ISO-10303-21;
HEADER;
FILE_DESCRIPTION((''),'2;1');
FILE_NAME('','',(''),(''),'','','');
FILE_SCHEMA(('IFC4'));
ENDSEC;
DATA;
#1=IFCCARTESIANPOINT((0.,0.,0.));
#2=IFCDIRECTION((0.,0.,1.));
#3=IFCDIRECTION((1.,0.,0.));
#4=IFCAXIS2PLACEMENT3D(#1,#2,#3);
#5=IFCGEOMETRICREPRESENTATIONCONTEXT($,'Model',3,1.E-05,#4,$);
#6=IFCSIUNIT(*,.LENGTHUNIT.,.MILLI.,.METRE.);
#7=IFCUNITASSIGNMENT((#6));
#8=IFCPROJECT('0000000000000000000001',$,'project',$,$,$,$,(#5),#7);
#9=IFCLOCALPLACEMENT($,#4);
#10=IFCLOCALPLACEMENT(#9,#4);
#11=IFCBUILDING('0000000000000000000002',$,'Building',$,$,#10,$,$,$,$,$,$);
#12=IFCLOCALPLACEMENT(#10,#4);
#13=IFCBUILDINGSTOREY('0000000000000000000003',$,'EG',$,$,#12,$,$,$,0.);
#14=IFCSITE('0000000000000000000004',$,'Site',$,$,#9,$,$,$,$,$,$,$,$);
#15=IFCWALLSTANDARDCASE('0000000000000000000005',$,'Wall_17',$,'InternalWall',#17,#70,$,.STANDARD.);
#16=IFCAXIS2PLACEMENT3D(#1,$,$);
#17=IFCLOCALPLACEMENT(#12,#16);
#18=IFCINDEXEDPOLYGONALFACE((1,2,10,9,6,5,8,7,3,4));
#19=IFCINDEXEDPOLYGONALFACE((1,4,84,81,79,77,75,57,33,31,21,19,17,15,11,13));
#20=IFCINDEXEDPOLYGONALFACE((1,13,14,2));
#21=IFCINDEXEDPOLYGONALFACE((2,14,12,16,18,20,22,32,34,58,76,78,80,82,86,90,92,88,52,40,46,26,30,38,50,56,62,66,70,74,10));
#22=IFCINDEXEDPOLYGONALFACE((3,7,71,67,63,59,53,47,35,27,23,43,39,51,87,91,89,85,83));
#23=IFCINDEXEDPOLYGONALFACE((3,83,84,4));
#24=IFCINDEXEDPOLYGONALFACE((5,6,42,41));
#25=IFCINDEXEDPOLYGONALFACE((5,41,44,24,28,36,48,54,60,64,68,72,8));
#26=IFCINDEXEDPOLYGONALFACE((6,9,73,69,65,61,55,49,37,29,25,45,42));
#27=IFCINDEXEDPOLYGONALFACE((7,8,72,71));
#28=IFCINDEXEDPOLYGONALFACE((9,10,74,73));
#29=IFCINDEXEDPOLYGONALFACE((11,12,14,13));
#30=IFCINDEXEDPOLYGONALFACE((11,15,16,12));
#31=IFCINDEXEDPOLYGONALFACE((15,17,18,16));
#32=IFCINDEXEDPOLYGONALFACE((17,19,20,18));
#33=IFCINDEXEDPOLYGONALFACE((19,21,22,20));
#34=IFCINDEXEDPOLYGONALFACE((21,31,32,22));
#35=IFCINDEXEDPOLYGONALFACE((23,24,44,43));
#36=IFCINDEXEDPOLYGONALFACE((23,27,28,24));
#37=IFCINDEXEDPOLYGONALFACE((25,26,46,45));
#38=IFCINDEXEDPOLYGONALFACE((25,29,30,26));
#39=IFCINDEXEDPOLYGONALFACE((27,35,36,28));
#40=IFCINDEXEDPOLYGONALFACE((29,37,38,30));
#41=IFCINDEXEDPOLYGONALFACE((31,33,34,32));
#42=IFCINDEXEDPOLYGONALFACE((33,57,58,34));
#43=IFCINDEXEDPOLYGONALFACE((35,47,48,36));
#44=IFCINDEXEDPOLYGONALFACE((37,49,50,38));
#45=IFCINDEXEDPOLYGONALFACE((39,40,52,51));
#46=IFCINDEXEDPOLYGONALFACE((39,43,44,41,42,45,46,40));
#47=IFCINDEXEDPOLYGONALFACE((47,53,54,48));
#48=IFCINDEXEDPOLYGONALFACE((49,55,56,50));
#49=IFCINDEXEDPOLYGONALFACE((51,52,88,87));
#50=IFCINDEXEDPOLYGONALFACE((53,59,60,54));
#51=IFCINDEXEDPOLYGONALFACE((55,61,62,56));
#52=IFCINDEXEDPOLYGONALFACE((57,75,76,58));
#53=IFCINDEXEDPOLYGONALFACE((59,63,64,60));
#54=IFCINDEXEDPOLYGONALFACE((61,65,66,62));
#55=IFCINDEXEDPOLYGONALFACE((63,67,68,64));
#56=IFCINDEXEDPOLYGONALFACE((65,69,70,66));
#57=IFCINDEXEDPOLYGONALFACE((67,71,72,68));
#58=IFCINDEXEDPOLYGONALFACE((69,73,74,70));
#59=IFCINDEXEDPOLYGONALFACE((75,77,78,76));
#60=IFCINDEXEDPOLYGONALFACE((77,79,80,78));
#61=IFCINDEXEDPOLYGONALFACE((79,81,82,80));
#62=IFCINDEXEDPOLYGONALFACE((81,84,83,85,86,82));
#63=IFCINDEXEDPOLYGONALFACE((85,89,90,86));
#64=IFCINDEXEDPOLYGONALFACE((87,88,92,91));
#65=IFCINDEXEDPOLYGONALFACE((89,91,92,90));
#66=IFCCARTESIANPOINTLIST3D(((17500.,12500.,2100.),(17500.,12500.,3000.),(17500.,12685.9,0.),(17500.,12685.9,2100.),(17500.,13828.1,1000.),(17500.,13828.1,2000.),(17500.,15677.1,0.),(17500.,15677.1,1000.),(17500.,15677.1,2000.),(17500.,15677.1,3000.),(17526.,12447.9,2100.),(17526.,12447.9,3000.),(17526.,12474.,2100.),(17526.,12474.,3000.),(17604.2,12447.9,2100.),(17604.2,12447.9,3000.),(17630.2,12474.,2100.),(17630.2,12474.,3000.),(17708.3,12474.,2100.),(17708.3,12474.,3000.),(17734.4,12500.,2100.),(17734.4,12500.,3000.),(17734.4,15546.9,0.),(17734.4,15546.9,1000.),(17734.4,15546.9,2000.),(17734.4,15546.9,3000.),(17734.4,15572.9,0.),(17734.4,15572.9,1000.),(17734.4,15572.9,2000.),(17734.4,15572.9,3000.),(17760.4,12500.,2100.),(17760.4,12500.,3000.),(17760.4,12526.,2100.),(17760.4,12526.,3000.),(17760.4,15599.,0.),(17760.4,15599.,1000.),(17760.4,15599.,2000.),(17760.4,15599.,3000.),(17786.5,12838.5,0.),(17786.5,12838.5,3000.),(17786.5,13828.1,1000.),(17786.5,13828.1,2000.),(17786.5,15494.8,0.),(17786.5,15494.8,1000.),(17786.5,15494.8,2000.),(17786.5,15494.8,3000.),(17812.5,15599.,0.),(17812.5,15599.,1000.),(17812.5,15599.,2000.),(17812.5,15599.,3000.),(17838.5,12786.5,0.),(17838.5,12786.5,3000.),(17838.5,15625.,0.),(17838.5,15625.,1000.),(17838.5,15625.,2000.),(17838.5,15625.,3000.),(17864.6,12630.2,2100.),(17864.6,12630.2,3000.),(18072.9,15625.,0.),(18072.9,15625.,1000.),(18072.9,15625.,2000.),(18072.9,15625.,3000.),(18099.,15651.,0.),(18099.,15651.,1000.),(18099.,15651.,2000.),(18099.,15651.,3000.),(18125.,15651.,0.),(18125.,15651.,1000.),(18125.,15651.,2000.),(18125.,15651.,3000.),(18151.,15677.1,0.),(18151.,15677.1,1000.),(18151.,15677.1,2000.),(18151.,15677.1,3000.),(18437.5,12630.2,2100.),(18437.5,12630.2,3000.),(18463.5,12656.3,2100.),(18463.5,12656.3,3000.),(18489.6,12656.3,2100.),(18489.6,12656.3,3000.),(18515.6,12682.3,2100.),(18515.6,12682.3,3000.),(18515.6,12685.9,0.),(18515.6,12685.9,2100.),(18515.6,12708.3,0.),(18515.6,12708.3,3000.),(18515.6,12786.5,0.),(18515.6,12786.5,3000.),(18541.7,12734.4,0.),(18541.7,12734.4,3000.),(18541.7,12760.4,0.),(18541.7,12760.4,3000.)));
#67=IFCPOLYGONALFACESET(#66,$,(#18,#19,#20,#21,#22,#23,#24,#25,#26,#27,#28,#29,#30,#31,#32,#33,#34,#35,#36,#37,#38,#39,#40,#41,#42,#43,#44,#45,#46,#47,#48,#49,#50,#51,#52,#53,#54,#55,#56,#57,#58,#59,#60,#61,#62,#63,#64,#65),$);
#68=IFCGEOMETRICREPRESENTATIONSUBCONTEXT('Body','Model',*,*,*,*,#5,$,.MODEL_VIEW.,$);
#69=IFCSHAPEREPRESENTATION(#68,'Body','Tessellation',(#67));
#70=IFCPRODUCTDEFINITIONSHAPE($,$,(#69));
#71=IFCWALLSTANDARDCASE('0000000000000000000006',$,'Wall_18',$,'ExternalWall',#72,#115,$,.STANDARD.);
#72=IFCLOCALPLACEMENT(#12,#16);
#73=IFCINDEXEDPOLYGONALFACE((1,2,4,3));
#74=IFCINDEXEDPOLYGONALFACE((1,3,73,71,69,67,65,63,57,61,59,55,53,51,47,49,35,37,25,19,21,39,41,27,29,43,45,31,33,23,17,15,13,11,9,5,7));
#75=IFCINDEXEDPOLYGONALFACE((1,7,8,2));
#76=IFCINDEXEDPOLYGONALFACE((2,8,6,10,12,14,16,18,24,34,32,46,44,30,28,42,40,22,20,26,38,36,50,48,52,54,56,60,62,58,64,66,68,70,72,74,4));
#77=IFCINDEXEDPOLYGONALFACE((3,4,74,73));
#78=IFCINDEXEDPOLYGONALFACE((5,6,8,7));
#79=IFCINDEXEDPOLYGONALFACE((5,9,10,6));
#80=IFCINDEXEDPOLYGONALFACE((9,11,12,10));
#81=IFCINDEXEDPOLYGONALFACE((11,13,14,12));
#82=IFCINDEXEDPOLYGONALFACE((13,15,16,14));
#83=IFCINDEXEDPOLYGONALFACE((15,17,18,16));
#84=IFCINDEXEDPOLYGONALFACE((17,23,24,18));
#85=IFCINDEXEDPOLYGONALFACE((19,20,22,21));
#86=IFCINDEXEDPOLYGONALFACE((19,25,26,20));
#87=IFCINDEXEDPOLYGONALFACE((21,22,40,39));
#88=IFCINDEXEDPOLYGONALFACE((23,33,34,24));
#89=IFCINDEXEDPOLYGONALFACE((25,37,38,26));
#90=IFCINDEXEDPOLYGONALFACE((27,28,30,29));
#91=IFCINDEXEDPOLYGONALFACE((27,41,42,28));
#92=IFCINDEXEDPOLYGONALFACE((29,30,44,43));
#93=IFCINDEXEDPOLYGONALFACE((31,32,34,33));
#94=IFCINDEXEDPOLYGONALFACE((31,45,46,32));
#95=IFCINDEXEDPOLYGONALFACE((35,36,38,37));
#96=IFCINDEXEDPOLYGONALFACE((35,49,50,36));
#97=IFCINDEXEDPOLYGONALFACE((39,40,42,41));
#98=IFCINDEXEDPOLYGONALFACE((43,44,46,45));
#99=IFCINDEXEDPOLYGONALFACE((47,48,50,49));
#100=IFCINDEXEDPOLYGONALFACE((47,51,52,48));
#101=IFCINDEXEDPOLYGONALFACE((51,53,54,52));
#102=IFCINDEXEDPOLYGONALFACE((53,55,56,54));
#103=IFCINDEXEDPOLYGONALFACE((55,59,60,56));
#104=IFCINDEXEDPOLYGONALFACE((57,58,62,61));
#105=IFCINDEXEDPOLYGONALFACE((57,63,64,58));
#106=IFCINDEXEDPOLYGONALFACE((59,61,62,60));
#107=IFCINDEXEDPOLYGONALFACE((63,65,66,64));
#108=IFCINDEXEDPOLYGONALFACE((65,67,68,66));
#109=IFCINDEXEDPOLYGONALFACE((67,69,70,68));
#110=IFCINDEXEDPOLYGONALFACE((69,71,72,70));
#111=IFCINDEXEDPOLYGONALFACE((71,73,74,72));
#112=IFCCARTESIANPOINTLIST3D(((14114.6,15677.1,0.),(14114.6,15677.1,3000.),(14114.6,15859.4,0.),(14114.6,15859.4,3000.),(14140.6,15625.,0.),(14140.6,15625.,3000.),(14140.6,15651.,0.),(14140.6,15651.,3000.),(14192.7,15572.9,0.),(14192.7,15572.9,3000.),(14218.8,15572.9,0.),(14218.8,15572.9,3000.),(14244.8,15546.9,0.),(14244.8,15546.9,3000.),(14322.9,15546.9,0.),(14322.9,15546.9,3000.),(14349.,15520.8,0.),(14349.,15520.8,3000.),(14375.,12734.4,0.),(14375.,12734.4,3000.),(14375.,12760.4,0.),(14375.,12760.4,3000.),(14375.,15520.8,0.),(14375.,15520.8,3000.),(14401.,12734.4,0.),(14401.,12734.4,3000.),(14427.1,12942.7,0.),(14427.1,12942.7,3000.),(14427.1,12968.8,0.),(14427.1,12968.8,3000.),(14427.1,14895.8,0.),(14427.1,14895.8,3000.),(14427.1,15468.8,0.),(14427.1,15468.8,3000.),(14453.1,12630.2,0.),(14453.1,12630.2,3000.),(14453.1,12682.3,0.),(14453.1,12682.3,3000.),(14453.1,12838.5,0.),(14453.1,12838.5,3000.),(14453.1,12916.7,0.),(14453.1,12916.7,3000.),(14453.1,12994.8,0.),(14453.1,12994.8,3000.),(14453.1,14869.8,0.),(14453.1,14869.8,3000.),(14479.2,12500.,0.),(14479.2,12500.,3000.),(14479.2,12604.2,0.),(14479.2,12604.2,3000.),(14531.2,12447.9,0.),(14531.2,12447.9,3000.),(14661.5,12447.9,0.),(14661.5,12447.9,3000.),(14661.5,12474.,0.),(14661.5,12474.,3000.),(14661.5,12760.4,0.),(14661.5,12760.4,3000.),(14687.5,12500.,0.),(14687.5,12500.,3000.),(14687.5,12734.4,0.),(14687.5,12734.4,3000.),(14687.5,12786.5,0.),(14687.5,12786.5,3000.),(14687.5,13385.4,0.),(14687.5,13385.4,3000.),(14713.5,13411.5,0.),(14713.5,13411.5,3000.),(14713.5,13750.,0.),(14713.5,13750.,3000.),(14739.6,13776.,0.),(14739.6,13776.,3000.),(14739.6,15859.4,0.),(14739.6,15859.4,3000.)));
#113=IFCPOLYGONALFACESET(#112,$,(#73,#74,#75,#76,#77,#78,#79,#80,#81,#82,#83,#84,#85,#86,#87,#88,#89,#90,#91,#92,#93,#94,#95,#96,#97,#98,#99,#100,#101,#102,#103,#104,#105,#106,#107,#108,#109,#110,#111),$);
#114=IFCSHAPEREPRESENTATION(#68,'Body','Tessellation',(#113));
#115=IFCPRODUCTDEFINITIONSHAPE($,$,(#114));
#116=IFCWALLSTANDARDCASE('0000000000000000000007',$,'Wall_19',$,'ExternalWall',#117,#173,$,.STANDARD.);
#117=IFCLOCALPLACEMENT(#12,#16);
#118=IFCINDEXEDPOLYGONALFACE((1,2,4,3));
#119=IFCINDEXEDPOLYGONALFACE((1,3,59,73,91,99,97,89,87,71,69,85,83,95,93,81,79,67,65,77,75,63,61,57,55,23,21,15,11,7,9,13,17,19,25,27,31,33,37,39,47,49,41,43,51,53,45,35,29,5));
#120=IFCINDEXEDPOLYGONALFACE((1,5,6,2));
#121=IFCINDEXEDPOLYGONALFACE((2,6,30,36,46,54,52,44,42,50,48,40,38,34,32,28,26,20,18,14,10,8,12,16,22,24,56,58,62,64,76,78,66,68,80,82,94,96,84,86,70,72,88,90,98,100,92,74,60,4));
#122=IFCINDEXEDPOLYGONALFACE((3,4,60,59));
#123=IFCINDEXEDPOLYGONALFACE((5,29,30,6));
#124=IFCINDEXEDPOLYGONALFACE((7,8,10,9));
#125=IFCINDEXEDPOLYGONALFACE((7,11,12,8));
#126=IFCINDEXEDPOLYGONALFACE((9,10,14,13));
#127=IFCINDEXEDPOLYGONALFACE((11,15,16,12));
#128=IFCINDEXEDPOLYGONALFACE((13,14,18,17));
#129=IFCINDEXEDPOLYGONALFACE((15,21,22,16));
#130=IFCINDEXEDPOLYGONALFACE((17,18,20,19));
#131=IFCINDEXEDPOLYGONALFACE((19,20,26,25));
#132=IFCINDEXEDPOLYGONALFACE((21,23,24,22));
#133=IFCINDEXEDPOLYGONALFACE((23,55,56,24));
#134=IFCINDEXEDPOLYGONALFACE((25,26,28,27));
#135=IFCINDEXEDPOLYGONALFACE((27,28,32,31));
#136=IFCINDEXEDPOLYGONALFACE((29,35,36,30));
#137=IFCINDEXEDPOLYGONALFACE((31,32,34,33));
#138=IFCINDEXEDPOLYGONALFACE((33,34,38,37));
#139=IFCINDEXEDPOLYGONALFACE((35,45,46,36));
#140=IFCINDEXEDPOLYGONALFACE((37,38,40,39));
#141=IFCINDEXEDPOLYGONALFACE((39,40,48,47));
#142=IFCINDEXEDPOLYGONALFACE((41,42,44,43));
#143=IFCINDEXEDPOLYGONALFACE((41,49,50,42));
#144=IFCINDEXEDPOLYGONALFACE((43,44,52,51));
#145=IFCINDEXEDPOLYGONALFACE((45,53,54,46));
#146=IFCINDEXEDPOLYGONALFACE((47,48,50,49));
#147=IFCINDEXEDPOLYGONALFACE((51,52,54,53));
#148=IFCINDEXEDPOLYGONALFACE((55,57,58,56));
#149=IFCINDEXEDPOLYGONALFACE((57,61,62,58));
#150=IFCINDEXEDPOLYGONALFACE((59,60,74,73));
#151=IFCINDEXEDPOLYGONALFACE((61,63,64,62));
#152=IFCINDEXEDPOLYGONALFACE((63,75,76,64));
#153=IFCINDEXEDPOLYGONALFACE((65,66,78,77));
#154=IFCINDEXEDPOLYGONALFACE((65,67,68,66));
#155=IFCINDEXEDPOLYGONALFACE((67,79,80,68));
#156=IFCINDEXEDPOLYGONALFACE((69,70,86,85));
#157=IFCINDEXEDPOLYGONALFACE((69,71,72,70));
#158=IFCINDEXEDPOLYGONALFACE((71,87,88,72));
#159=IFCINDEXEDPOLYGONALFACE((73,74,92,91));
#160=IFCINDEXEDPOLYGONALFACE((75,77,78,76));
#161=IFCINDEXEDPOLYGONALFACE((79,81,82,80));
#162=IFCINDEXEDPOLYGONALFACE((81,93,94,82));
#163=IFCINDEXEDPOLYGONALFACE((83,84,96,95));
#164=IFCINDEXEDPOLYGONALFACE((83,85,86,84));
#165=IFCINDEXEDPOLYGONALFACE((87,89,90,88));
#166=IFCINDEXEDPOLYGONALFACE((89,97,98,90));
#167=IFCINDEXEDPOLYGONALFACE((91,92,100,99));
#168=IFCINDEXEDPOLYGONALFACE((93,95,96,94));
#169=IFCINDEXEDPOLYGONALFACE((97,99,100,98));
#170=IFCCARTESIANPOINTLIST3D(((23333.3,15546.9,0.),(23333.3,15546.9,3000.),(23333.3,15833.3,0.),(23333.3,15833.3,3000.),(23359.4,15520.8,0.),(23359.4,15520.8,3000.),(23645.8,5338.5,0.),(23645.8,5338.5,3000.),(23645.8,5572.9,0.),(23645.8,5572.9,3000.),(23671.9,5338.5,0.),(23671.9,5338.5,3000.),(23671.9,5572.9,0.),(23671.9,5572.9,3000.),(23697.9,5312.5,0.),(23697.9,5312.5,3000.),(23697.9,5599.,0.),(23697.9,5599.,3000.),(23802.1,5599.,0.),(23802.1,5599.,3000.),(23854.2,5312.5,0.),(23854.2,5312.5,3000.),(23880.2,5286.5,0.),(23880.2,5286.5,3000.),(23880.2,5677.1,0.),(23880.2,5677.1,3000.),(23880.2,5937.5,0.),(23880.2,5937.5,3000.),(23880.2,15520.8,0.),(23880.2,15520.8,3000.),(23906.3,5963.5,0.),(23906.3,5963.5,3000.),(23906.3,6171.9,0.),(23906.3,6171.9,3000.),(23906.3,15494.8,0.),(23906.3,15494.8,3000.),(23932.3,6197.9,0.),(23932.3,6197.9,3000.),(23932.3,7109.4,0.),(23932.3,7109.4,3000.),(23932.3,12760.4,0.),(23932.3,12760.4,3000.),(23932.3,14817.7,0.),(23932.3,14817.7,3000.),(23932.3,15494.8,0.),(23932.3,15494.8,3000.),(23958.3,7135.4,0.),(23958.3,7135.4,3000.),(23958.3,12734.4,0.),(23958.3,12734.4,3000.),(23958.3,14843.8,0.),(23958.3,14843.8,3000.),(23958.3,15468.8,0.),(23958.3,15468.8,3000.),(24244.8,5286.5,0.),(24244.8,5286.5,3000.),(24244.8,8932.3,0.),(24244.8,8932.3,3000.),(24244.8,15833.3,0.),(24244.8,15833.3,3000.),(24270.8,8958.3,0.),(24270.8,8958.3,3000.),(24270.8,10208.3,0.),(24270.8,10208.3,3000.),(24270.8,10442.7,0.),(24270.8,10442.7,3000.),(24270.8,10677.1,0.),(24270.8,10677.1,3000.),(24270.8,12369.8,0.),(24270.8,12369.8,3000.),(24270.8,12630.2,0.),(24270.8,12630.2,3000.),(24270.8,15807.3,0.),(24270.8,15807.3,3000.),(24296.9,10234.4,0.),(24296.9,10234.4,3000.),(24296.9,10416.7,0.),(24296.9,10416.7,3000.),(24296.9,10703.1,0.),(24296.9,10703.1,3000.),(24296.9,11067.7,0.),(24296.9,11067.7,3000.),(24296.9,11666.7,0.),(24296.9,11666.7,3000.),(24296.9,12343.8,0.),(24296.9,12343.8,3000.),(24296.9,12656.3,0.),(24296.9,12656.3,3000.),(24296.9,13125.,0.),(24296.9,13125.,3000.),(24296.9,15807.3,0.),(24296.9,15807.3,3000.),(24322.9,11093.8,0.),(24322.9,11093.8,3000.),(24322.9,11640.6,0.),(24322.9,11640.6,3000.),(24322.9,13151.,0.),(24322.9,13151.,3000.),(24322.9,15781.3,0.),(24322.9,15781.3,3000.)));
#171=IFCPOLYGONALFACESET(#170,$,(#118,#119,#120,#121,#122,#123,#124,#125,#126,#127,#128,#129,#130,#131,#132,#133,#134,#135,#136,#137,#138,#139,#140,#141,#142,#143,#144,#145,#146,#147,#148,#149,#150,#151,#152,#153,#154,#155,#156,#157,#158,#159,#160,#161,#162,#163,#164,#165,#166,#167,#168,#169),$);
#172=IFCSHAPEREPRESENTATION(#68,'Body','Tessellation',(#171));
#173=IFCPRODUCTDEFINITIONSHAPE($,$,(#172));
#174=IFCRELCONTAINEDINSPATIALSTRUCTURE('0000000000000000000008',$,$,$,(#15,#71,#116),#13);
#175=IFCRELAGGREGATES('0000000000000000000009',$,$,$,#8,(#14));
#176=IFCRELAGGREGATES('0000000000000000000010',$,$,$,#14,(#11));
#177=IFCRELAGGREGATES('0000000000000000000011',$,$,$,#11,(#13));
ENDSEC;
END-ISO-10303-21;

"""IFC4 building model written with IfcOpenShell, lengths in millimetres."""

from ifc_helpers import new_model, si_unit, frame, origin_with_axes, place, context, subcontext, project, spatial, polyline, rectangle, outline, extrude, element, save


model = new_model("IFC4")

# Units and contexts
model_context = context("Model", 3, precision=1e-05, world=origin_with_axes())
body_context = subcontext(model_context, "Body", "Model", "MODEL_VIEW")
ifc_project = project(units=[si_unit("LENGTHUNIT", "METRE", prefix="MILLI")], contexts=[model_context])

# Site, building, storey
site_placement = place(None, origin_with_axes())
site = spatial("IfcSite", under=ifc_project, at=site_placement, Name="Site")
building_placement = place(site_placement, origin_with_axes())
building = spatial("IfcBuilding", under=site, at=building_placement, Name="Building")
storey_placement = place(building_placement, origin_with_axes())
storey = spatial("IfcBuildingStorey", under=building, at=storey_placement, Name="EG", Elevation=0.0)

# Wall, openings
wall_1_placement = place(storey_placement, origin_with_axes())
wall_1 = element("IfcWallStandardCase", 1, at=wall_1_placement, inside=storey, Name="Wall_17", ObjectType="InternalWall", PredefinedType="STANDARD", context=body_context, shape_type="SweptSolid", body=[
    extrude(outline(polyline([(17526.0, 12447.9, 0.0), (17526.0, 12474.0, 0.0), (17500.0, 12500.0, 0.0), (17500.0, 15677.1, 0.0), (18151.0, 15677.1, 0.0), (18125.0, 15651.0, 0.0), (18099.0, 15651.0, 0.0), (18072.9, 15625.0, 0.0), (17838.5, 15625.0, 0.0), (17812.5, 15599.0, 0.0), (17760.4, 15599.0, 0.0), (17734.4, 15572.9, 0.0), (17734.4, 15546.9, 0.0), (17786.5, 15494.8, 0.0), (17786.5, 12838.5, 0.0), (17838.5, 12786.5, 0.0), (18515.6, 12786.5, 0.0), (18541.7, 12760.4, 0.0), (18541.7, 12734.4, 0.0), (18515.6, 12708.3, 0.0), (18515.6, 12682.3, 0.0), (18489.6, 12656.3, 0.0), (18463.5, 12656.3, 0.0), (18437.5, 12630.2, 0.0), (17864.6, 12630.2, 0.0), (17760.4, 12526.0, 0.0), (17760.4, 12500.0, 0.0), (17734.4, 12500.0, 0.0), (17708.3, 12474.0, 0.0), (17630.2, 12474.0, 0.0), (17604.2, 12447.9, 0.0), (17526.0, 12447.9, 0.0)])), origin_with_axes(), (0.0, 0.0, 1.0), 3000.0),
])
opening_1_placement = place(wall_1_placement, origin_with_axes())
element("IfcOpeningElement", 2, at=opening_1_placement, inside=storey, cuts=wall_1, context=body_context, shape_type="SweptSolid", body=[
    extrude(rectangle(XDim=450.0, YDim=1041.7), frame((18020.8, 12460.9, 0.0), z_axis=(0.0, 0.0, 1.0), x_axis=(0.0, 1.0, 0.0)), (0.0, 0.0, 1.0), 2100.0),
])
opening_2_placement = place(wall_1_placement, origin_with_axes())
element("IfcOpeningElement", 3, at=opening_2_placement, inside=storey, cuts=wall_1, context=body_context, shape_type="SweptSolid", body=[
    extrude(rectangle(XDim=1849.0, YDim=1041.7), frame((18020.8, 14752.6, 1000.0), z_axis=(0.0, 0.0, 1.0), x_axis=(0.0, 1.0, 0.0)), (0.0, 0.0, 1.0), 1000.0),
])

# Wall, opening
wall_2_placement = place(storey_placement, origin_with_axes())
wall_2 = element("IfcWallStandardCase", 4, at=wall_2_placement, inside=storey, Name="Wall_18", ObjectType="ExternalWall", PredefinedType="STANDARD", context=body_context, shape_type="SweptSolid", body=[
    extrude(outline(polyline([(14531.2, 12447.9, 0.0), (14479.2, 12500.0, 0.0), (14479.2, 12604.2, 0.0), (14453.1, 12630.2, 0.0), (14453.1, 12682.3, 0.0), (14401.0, 12734.4, 0.0), (14375.0, 12734.4, 0.0), (14375.0, 12760.4, 0.0), (14453.1, 12838.5, 0.0), (14453.1, 12916.7, 0.0), (14427.1, 12942.7, 0.0), (14427.1, 12968.8, 0.0), (14453.1, 12994.8, 0.0), (14453.1, 14869.8, 0.0), (14427.1, 14895.8, 0.0), (14427.1, 15468.8, 0.0), (14375.0, 15520.8, 0.0), (14349.0, 15520.8, 0.0), (14322.9, 15546.9, 0.0), (14244.8, 15546.9, 0.0), (14218.8, 15572.9, 0.0), (14192.7, 15572.9, 0.0), (14140.6, 15625.0, 0.0), (14140.6, 15651.0, 0.0), (14114.6, 15677.1, 0.0), (14114.6, 15859.4, 0.0), (14739.6, 15859.4, 0.0), (14739.6, 13776.0, 0.0), (14713.5, 13750.0, 0.0), (14713.5, 13411.5, 0.0), (14687.5, 13385.4, 0.0), (14687.5, 12786.5, 0.0), (14661.5, 12760.4, 0.0), (14687.5, 12734.4, 0.0), (14687.5, 12500.0, 0.0), (14661.5, 12474.0, 0.0), (14661.5, 12447.9, 0.0), (14531.2, 12447.9, 0.0)])), origin_with_axes(), (0.0, 0.0, 1.0), 3000.0),
])
opening_3_placement = place(wall_2_placement, origin_with_axes())
element("IfcOpeningElement", 5, at=opening_3_placement, inside=storey, cuts=wall_2, context=body_context, shape_type="SweptSolid", body=[
    extrude(rectangle(XDim=900.0, YDim=625.0), frame((14301.5, 11982.3, 0.0), z_axis=(0.0, 0.0, 1.0), x_axis=(0.0, 1.0, 0.0)), (0.0, 0.0, 1.0), 2100.0),
])

# Wall
wall_3_placement = place(storey_placement, origin_with_axes())
element("IfcWallStandardCase", 6, at=wall_3_placement, inside=storey, Name="Wall_19", ObjectType="ExternalWall", PredefinedType="STANDARD", context=body_context, shape_type="SweptSolid", body=[
    extrude(outline(polyline([(23880.2, 5286.5, 0.0), (23854.2, 5312.5, 0.0), (23697.9, 5312.5, 0.0), (23671.9, 5338.5, 0.0), (23645.8, 5338.5, 0.0), (23645.8, 5572.9, 0.0), (23671.9, 5572.9, 0.0), (23697.9, 5599.0, 0.0), (23802.1, 5599.0, 0.0), (23880.2, 5677.1, 0.0), (23880.2, 5937.5, 0.0), (23906.3, 5963.5, 0.0), (23906.3, 6171.9, 0.0), (23932.3, 6197.9, 0.0), (23932.3, 7109.4, 0.0), (23958.3, 7135.4, 0.0), (23958.3, 12734.4, 0.0), (23932.3, 12760.4, 0.0), (23932.3, 14817.7, 0.0), (23958.3, 14843.8, 0.0), (23958.3, 15468.8, 0.0), (23932.3, 15494.8, 0.0), (23906.3, 15494.8, 0.0), (23880.2, 15520.8, 0.0), (23359.4, 15520.8, 0.0), (23333.3, 15546.9, 0.0), (23333.3, 15833.3, 0.0), (24244.8, 15833.3, 0.0), (24270.8, 15807.3, 0.0), (24296.9, 15807.3, 0.0), (24322.9, 15781.3, 0.0), (24322.9, 13151.0, 0.0), (24296.9, 13125.0, 0.0), (24296.9, 12656.3, 0.0), (24270.8, 12630.2, 0.0), (24270.8, 12369.8, 0.0), (24296.9, 12343.8, 0.0), (24296.9, 11666.7, 0.0), (24322.9, 11640.6, 0.0), (24322.9, 11093.8, 0.0), (24296.9, 11067.7, 0.0), (24296.9, 10703.1, 0.0), (24270.8, 10677.1, 0.0), (24270.8, 10442.7, 0.0), (24296.9, 10416.7, 0.0), (24296.9, 10234.4, 0.0), (24270.8, 10208.3, 0.0), (24270.8, 8958.3, 0.0), (24244.8, 8932.3, 0.0), (24244.8, 5286.5, 0.0), (23880.2, 5286.5, 0.0)])), origin_with_axes(), (0.0, 0.0, 1.0), 3000.0),
])

save(model, "model.ifc")
